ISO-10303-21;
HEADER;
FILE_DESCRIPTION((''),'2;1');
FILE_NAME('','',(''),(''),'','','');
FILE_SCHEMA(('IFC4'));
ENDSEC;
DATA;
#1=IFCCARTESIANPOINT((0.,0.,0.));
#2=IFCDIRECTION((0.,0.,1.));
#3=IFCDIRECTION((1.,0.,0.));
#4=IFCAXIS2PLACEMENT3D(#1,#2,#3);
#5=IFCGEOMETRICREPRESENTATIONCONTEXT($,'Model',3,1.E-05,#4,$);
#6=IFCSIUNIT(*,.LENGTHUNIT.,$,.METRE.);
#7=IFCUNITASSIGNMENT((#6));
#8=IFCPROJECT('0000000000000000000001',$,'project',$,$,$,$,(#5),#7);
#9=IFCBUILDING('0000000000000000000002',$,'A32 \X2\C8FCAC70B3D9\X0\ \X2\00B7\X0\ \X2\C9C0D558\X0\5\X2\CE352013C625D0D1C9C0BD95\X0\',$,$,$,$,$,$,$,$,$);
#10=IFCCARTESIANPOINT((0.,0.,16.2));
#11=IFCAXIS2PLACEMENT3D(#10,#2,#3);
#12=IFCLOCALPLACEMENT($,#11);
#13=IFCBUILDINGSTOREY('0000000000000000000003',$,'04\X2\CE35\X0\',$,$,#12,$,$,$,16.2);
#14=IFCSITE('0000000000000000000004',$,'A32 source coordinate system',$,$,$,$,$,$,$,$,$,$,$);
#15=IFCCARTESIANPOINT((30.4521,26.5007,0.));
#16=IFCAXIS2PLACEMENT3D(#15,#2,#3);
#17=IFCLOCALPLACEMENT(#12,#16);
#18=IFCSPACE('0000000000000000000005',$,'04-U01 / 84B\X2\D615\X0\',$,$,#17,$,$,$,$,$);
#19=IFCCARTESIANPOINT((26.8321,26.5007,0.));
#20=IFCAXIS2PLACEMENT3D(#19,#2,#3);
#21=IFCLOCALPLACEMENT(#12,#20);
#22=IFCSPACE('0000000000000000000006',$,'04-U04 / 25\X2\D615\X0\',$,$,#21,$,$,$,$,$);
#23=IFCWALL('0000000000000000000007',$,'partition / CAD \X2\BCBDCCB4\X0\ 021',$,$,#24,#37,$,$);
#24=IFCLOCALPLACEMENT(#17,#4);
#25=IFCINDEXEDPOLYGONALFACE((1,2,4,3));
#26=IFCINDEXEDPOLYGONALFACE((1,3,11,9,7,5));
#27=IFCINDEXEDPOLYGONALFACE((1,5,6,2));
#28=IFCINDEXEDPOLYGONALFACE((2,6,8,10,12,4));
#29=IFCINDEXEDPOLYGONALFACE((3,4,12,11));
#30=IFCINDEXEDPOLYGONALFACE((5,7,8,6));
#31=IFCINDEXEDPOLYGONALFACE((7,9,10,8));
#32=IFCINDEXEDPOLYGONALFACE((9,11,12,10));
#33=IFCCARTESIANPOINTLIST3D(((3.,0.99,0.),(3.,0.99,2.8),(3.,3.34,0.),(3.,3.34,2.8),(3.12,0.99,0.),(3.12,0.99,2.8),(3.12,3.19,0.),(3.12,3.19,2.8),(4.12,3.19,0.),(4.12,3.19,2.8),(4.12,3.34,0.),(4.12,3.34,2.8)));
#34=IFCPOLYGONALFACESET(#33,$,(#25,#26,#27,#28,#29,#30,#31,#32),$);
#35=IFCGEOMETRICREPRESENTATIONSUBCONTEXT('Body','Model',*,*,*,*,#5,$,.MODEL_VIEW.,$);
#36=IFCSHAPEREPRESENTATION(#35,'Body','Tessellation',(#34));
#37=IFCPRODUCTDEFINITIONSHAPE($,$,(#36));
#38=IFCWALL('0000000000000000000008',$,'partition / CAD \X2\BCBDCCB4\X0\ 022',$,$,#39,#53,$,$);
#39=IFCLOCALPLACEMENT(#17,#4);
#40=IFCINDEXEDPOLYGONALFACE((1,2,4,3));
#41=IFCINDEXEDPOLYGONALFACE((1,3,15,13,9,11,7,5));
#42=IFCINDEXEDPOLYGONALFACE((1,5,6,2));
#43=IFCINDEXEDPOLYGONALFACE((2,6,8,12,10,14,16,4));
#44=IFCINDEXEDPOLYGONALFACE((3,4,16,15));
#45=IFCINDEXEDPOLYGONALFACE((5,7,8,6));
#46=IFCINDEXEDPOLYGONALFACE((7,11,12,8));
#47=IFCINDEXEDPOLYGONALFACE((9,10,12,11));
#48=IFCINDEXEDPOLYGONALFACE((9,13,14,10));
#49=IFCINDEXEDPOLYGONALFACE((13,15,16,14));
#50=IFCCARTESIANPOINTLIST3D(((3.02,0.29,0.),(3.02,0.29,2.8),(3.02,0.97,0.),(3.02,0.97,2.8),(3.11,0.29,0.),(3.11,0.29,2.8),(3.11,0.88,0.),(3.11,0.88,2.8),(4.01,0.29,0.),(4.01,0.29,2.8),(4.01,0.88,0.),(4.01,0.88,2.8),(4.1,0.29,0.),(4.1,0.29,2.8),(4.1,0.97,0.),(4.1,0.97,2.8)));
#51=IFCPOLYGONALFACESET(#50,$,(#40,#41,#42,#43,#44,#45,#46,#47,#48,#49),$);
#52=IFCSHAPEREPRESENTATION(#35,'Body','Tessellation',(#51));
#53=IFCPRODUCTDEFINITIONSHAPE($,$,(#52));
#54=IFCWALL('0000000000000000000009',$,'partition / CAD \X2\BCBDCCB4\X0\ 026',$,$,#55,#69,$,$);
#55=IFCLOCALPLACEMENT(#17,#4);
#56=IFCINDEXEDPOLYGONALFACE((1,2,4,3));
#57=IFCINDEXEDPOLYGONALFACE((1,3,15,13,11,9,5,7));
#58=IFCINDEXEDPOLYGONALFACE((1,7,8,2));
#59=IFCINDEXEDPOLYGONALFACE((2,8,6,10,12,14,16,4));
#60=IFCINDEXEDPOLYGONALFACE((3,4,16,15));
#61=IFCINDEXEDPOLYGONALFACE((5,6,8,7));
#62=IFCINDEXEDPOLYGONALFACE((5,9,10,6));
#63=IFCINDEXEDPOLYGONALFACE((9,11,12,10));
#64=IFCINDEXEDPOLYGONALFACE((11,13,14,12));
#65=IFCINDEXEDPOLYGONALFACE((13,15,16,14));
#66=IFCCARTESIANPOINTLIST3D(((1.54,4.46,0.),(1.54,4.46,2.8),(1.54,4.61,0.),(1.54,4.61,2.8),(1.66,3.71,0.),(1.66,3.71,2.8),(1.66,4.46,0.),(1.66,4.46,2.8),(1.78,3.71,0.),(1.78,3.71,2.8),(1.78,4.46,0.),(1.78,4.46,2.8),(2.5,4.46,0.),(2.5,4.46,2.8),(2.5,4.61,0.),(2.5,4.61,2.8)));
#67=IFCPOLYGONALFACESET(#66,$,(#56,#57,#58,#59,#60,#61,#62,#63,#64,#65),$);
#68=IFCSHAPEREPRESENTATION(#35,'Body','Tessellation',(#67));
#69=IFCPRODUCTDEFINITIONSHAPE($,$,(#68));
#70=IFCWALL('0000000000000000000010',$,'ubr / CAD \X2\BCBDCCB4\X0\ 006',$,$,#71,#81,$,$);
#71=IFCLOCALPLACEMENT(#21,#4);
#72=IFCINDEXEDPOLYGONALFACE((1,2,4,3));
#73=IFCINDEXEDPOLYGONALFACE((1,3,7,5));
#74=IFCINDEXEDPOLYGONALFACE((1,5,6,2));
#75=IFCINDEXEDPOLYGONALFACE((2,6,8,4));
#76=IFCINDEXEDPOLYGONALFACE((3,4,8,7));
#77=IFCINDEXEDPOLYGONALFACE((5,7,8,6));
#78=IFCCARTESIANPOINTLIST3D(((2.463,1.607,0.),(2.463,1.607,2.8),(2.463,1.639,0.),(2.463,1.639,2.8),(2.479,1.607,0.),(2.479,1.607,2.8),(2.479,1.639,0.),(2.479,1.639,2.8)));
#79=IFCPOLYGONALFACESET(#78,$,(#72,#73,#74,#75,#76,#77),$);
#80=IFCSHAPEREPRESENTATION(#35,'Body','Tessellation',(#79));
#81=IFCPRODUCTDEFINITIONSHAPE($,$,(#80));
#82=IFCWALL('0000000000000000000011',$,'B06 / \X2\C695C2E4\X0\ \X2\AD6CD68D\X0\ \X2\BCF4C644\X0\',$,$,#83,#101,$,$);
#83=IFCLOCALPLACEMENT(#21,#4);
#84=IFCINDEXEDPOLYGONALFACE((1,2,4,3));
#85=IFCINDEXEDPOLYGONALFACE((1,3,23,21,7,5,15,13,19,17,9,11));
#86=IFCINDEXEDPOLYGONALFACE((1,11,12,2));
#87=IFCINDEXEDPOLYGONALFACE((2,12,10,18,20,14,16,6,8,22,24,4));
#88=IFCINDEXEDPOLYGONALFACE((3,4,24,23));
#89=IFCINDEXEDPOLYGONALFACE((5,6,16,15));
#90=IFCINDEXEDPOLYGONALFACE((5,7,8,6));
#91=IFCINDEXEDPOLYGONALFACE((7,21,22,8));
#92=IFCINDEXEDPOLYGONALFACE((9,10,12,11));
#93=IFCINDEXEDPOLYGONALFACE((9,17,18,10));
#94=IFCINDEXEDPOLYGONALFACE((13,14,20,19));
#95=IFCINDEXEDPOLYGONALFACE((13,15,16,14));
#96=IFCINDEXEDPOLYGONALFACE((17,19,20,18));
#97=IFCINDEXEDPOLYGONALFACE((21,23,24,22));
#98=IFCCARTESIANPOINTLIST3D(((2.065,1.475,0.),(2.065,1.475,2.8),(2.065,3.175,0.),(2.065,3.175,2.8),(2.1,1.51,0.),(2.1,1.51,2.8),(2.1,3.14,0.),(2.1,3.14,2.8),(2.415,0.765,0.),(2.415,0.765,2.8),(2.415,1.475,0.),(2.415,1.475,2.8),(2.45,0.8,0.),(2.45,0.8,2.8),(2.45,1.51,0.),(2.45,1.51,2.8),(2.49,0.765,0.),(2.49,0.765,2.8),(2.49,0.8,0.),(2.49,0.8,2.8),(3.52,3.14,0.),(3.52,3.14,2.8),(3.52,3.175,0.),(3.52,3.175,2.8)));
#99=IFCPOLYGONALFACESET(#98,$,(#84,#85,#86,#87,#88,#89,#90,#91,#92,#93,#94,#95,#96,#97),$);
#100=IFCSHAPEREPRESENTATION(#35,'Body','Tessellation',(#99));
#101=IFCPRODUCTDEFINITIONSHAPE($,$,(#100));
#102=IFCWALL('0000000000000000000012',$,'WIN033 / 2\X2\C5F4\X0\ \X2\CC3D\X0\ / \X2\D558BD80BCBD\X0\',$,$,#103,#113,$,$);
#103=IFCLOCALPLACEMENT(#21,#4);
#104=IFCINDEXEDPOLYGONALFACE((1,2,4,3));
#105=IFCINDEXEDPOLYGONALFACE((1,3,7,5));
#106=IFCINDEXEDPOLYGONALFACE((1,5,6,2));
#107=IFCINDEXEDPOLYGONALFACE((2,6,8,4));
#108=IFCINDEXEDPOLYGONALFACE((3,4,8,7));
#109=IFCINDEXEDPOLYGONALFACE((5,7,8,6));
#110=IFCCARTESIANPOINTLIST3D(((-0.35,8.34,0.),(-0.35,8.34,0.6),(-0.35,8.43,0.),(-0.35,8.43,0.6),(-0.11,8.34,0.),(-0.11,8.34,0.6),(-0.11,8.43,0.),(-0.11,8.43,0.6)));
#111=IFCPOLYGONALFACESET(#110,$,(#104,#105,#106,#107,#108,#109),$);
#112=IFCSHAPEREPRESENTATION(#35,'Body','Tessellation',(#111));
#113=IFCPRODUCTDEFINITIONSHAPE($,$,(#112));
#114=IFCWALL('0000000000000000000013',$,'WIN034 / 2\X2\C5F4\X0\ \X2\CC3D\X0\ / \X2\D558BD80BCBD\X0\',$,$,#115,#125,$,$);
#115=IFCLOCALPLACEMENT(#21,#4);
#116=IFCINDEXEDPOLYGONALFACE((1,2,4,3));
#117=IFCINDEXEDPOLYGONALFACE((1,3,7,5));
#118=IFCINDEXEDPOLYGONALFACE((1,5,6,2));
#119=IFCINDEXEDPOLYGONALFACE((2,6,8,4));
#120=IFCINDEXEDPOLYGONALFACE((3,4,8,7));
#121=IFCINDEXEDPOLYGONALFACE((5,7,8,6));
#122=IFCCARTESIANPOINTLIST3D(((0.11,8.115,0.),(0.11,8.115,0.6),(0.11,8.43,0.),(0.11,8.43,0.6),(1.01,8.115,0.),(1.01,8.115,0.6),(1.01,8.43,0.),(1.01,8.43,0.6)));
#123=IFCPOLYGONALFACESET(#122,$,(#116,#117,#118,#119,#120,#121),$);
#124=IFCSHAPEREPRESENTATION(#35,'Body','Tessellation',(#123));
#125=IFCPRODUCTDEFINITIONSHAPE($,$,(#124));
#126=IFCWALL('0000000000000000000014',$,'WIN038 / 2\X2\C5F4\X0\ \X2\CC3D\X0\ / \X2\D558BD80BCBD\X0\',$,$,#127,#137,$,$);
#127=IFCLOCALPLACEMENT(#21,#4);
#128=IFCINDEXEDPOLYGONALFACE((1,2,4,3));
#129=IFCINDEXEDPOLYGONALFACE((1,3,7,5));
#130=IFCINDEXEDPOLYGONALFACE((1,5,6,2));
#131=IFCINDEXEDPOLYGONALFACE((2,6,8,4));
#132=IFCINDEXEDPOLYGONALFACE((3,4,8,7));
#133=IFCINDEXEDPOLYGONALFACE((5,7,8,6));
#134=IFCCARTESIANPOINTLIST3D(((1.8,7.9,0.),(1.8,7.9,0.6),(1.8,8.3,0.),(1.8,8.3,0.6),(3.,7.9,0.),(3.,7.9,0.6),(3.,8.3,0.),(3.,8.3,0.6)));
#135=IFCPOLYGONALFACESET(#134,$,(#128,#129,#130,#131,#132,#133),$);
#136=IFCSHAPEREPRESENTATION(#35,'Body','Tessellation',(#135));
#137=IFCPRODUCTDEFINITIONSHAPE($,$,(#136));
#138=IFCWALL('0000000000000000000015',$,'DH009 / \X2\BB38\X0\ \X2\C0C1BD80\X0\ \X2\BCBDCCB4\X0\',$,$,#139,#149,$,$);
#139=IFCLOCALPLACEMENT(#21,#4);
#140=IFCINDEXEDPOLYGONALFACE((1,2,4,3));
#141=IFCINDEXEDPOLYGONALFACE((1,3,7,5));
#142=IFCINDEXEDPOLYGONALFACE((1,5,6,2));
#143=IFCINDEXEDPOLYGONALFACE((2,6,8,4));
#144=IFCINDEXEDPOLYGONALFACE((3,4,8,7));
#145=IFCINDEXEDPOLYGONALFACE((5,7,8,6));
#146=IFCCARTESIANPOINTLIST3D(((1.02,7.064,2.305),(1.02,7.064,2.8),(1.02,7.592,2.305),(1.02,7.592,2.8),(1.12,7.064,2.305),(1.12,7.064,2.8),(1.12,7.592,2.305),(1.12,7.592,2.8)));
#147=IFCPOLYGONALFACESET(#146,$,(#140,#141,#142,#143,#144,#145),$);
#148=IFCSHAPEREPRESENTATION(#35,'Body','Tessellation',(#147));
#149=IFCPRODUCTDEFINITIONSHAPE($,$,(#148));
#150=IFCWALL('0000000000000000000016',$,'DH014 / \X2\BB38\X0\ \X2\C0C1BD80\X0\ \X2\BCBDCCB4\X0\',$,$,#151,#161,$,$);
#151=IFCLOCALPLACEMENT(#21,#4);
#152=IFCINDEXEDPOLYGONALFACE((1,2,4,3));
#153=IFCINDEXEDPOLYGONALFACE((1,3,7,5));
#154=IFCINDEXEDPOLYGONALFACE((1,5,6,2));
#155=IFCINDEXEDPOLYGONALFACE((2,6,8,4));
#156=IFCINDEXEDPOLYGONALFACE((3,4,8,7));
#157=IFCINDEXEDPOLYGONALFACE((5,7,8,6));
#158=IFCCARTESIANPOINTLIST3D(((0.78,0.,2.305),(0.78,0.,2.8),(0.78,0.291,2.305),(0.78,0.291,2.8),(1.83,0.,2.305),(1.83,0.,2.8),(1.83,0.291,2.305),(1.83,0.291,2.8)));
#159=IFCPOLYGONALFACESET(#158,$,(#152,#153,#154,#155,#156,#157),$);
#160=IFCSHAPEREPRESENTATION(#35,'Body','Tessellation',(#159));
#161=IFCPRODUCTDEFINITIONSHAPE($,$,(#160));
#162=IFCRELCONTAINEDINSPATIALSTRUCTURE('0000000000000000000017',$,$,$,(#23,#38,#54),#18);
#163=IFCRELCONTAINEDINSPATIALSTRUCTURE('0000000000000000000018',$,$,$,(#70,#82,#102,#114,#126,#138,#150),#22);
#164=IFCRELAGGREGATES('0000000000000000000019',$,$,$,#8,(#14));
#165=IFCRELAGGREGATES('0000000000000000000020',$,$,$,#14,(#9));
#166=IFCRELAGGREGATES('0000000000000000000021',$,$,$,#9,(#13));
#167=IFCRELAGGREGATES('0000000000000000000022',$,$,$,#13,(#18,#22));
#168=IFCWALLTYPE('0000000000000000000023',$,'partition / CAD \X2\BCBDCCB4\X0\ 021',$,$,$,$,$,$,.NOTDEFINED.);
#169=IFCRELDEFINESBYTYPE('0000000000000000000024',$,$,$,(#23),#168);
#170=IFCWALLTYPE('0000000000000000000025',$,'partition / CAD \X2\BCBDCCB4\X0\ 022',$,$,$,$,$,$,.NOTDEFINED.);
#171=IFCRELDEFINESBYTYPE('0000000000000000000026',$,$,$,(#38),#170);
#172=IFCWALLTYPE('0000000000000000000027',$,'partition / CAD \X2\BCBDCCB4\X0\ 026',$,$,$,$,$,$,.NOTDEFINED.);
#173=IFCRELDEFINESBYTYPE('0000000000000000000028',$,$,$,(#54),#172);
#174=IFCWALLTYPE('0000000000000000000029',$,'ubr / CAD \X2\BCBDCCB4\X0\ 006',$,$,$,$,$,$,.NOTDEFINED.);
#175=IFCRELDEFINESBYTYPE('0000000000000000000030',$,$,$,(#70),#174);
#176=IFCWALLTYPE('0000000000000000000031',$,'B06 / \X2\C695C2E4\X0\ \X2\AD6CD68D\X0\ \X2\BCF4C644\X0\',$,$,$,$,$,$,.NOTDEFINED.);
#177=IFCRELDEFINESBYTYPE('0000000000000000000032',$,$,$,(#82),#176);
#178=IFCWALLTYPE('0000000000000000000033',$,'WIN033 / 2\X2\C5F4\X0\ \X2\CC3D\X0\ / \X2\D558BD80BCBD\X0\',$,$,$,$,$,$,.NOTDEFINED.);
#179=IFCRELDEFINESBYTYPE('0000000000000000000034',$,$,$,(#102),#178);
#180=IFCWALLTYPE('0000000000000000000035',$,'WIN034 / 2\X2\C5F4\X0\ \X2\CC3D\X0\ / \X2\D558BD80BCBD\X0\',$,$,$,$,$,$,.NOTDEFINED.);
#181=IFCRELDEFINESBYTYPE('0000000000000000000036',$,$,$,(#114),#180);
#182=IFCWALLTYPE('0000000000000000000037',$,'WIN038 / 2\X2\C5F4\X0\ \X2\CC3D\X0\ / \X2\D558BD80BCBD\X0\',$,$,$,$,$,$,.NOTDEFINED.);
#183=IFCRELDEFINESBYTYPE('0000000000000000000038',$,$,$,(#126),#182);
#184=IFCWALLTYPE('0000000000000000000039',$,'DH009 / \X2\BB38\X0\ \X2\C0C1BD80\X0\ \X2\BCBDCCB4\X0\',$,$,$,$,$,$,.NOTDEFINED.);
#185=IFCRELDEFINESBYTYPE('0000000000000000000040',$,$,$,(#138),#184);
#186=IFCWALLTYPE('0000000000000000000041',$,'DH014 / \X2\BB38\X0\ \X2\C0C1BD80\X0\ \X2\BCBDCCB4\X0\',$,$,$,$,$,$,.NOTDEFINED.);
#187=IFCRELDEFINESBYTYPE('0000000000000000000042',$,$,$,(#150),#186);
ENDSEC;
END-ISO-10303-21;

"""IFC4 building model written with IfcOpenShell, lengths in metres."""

from ifc_helpers import new_model, si_unit, frame, origin, origin_with_axes, place, context, subcontext, project, spatial, polyline, outline, extrude, source, transform, mapped, type_object, type_shapes, element, save


model = new_model("IFC4")

# Units and contexts
model_context = context("Model", 3, precision=1e-05, world=origin_with_axes())
body_context = subcontext(model_context, "Body", "Model", "MODEL_VIEW")
ifc_project = project(units=[si_unit("LENGTHUNIT", "METRE")], contexts=[model_context])

# Site, building, storey, space
site = spatial("IfcSite", under=ifc_project, Name="A32 source coordinate system")
building = spatial("IfcBuilding", under=site, Name="A32 주거동 · 지하5층–옥탑지붕")
storey_placement = place(None, frame((0.0, 0.0, 16.2), z_axis=(0.0, 0.0, 1.0), x_axis=(1.0, 0.0, 0.0)))
storey = spatial("IfcBuildingStorey", under=building, at=storey_placement, Name="04층", Elevation=16.2)
space_1_placement = place(storey_placement, frame((30.4521, 26.5007, 0.0), z_axis=(0.0, 0.0, 1.0), x_axis=(1.0, 0.0, 0.0)))
space_1 = spatial("IfcSpace", under=storey, at=space_1_placement, Name="04-U01 / 84B형")

# Walls
wall_type_1 = type_object("IfcWallType", Name="partition / CAD 벽체 021", PredefinedType="NOTDEFINED")
shared_shape_1 = source(origin(), body_context, "Body", "SweptSolid", [
    extrude(outline(polyline([(4.12, 3.34), (4.12, 3.19), (3.12, 3.19), (3.12, 0.99), (3.0, 0.99), (3.0, 3.34), (4.12, 3.34)])), origin(), (0.0, 0.0, 1.0), 2.8),
])
type_shapes(wall_type_1, [shared_shape_1])
wall_1_placement = place(space_1_placement, origin_with_axes())
element("IfcWall", 1, at=wall_1_placement, inside=space_1, type_object=wall_type_1, Name="partition / CAD 벽체 021", context=body_context, shape_type="MappedRepresentation", body=[
    mapped(shared_shape_1, transform((0.0, 0.0, 0.0), scale=1.0)),
])
wall_type_2 = type_object("IfcWallType", Name="partition / CAD 벽체 022", PredefinedType="NOTDEFINED")
shared_shape_2 = source(origin(), body_context, "Body", "SweptSolid", [
    extrude(outline(polyline([(4.1, 0.97), (4.1, 0.29), (4.01, 0.29), (4.01, 0.88), (3.11, 0.88), (3.11, 0.29), (3.02, 0.29), (3.02, 0.97), (4.1, 0.97)])), origin(), (0.0, 0.0, 1.0), 2.8),
])
type_shapes(wall_type_2, [shared_shape_2])
wall_2_placement = place(space_1_placement, origin_with_axes())
element("IfcWall", 2, at=wall_2_placement, inside=space_1, type_object=wall_type_2, Name="partition / CAD 벽체 022", context=body_context, shape_type="MappedRepresentation", body=[
    mapped(shared_shape_2, transform((0.0, 0.0, 0.0), scale=1.0)),
])
wall_type_3 = type_object("IfcWallType", Name="partition / CAD 벽체 026", PredefinedType="NOTDEFINED")
shared_shape_3 = source(origin(), body_context, "Body", "SweptSolid", [
    extrude(outline(polyline([(1.54, 4.46), (1.54, 4.61), (2.5, 4.61), (2.5, 4.46), (1.78, 4.46), (1.78, 3.71), (1.66, 3.71), (1.66, 4.46), (1.54, 4.46)])), origin(), (0.0, 0.0, 1.0), 2.8),
])
type_shapes(wall_type_3, [shared_shape_3])
wall_3_placement = place(space_1_placement, origin_with_axes())
element("IfcWall", 3, at=wall_3_placement, inside=space_1, type_object=wall_type_3, Name="partition / CAD 벽체 026", context=body_context, shape_type="MappedRepresentation", body=[
    mapped(shared_shape_3, transform((0.0, 0.0, 0.0), scale=1.0)),
])

# Shared definitions
space_2_placement = place(storey_placement, frame((26.8321, 26.5007, 0.0), z_axis=(0.0, 0.0, 1.0), x_axis=(1.0, 0.0, 0.0)))
space_2 = spatial("IfcSpace", under=storey, at=space_2_placement, Name="04-U04 / 25형")

# Walls
wall_type_4 = type_object("IfcWallType", Name="ubr / CAD 벽체 006", PredefinedType="NOTDEFINED")
shared_shape_4 = source(origin(), body_context, "Body", "SweptSolid", [
    extrude(outline(polyline([(2.463, 1.639), (2.479, 1.639), (2.479, 1.607), (2.463, 1.607), (2.463, 1.639)])), origin(), (0.0, 0.0, 1.0), 2.8),
])
type_shapes(wall_type_4, [shared_shape_4])
wall_4_placement = place(space_2_placement, origin_with_axes())
element("IfcWall", 4, at=wall_4_placement, inside=space_2, type_object=wall_type_4, Name="ubr / CAD 벽체 006", context=body_context, shape_type="MappedRepresentation", body=[
    mapped(shared_shape_4, transform((0.0, 0.0, 0.0), scale=1.0)),
])
wall_type_5 = type_object("IfcWallType", Name="B06 / 욕실 구획 보완", PredefinedType="NOTDEFINED")
shared_shape_5 = source(origin(), body_context, "Body", "SweptSolid", [
    extrude(outline(polyline([(3.52, 3.14), (2.1, 3.14), (2.1, 1.51), (2.45, 1.51), (2.45, 0.8), (2.49, 0.8), (2.49, 0.765), (2.415, 0.765), (2.415, 1.475), (2.065, 1.475), (2.065, 3.175), (3.52, 3.175), (3.52, 3.14)])), origin(), (0.0, 0.0, 1.0), 2.8),
])
type_shapes(wall_type_5, [shared_shape_5])
wall_5_placement = place(space_2_placement, origin_with_axes())
element("IfcWall", 5, at=wall_5_placement, inside=space_2, type_object=wall_type_5, Name="B06 / 욕실 구획 보완", context=body_context, shape_type="MappedRepresentation", body=[
    mapped(shared_shape_5, transform((0.0, 0.0, 0.0), scale=1.0)),
])
wall_type_6 = type_object("IfcWallType", Name="WIN033 / 2열 창 / 하부벽", PredefinedType="NOTDEFINED")
shared_shape_6 = source(origin(), body_context, "Body", "SweptSolid", [
    extrude(outline(polyline([(-0.11, 8.43), (-0.11, 8.34), (-0.35, 8.34), (-0.35, 8.43), (-0.11, 8.43)])), origin(), (0.0, 0.0, 1.0), 0.6),
])
type_shapes(wall_type_6, [shared_shape_6])
wall_6_placement = place(space_2_placement, origin_with_axes())
element("IfcWall", 6, at=wall_6_placement, inside=space_2, type_object=wall_type_6, Name="WIN033 / 2열 창 / 하부벽", context=body_context, shape_type="MappedRepresentation", body=[
    mapped(shared_shape_6, transform((0.0, 0.0, 0.0), scale=1.0)),
])
wall_type_7 = type_object("IfcWallType", Name="WIN034 / 2열 창 / 하부벽", PredefinedType="NOTDEFINED")
shared_shape_7 = source(origin(), body_context, "Body", "SweptSolid", [
    extrude(outline(polyline([(0.11, 8.115), (0.11, 8.43), (1.01, 8.43), (1.01, 8.115), (0.11, 8.115)])), origin(), (0.0, 0.0, 1.0), 0.6),
])
type_shapes(wall_type_7, [shared_shape_7])
wall_7_placement = place(space_2_placement, origin_with_axes())
element("IfcWall", 7, at=wall_7_placement, inside=space_2, type_object=wall_type_7, Name="WIN034 / 2열 창 / 하부벽", context=body_context, shape_type="MappedRepresentation", body=[
    mapped(shared_shape_7, transform((0.0, 0.0, 0.0), scale=1.0)),
])
wall_type_8 = type_object("IfcWallType", Name="WIN038 / 2열 창 / 하부벽", PredefinedType="NOTDEFINED")
shared_shape_8 = source(origin(), body_context, "Body", "SweptSolid", [
    extrude(outline(polyline([(1.8, 7.9), (1.8, 8.3), (3.0, 8.3), (3.0, 7.9), (1.8, 7.9)])), origin(), (0.0, 0.0, 1.0), 0.6),
])
type_shapes(wall_type_8, [shared_shape_8])
wall_8_placement = place(space_2_placement, origin_with_axes())
element("IfcWall", 8, at=wall_8_placement, inside=space_2, type_object=wall_type_8, Name="WIN038 / 2열 창 / 하부벽", context=body_context, shape_type="MappedRepresentation", body=[
    mapped(shared_shape_8, transform((0.0, 0.0, 0.0), scale=1.0)),
])
wall_type_9 = type_object("IfcWallType", Name="DH009 / 문 상부 벽체", PredefinedType="NOTDEFINED")
shared_shape_9 = source(origin(), body_context, "Body", "SweptSolid", [
    extrude(outline(polyline([(1.02, 7.064), (1.02, 7.592), (1.12, 7.592), (1.12, 7.064), (1.02, 7.064)])), frame((0.0, 0.0, 2.305)), (0.0, 0.0, 1.0), 0.495),
])
type_shapes(wall_type_9, [shared_shape_9])
wall_9_placement = place(space_2_placement, origin_with_axes())
element("IfcWall", 9, at=wall_9_placement, inside=space_2, type_object=wall_type_9, Name="DH009 / 문 상부 벽체", context=body_context, shape_type="MappedRepresentation", body=[
    mapped(shared_shape_9, transform((0.0, 0.0, 0.0), scale=1.0)),
])
wall_type_10 = type_object("IfcWallType", Name="DH014 / 문 상부 벽체", PredefinedType="NOTDEFINED")
shared_shape_10 = source(origin(), body_context, "Body", "SweptSolid", [
    extrude(outline(polyline([(0.78, 0.291), (1.83, 0.291), (1.83, 0.0), (0.78, 0.0), (0.78, 0.291)])), frame((0.0, 0.0, 2.305)), (0.0, 0.0, 1.0), 0.495),
])
type_shapes(wall_type_10, [shared_shape_10])
wall_10_placement = place(space_2_placement, origin_with_axes())
element("IfcWall", 10, at=wall_10_placement, inside=space_2, type_object=wall_type_10, Name="DH014 / 문 상부 벽체", context=body_context, shape_type="MappedRepresentation", body=[
    mapped(shared_shape_10, transform((0.0, 0.0, 0.0), scale=1.0)),
])

save(model, "model.ifc")
